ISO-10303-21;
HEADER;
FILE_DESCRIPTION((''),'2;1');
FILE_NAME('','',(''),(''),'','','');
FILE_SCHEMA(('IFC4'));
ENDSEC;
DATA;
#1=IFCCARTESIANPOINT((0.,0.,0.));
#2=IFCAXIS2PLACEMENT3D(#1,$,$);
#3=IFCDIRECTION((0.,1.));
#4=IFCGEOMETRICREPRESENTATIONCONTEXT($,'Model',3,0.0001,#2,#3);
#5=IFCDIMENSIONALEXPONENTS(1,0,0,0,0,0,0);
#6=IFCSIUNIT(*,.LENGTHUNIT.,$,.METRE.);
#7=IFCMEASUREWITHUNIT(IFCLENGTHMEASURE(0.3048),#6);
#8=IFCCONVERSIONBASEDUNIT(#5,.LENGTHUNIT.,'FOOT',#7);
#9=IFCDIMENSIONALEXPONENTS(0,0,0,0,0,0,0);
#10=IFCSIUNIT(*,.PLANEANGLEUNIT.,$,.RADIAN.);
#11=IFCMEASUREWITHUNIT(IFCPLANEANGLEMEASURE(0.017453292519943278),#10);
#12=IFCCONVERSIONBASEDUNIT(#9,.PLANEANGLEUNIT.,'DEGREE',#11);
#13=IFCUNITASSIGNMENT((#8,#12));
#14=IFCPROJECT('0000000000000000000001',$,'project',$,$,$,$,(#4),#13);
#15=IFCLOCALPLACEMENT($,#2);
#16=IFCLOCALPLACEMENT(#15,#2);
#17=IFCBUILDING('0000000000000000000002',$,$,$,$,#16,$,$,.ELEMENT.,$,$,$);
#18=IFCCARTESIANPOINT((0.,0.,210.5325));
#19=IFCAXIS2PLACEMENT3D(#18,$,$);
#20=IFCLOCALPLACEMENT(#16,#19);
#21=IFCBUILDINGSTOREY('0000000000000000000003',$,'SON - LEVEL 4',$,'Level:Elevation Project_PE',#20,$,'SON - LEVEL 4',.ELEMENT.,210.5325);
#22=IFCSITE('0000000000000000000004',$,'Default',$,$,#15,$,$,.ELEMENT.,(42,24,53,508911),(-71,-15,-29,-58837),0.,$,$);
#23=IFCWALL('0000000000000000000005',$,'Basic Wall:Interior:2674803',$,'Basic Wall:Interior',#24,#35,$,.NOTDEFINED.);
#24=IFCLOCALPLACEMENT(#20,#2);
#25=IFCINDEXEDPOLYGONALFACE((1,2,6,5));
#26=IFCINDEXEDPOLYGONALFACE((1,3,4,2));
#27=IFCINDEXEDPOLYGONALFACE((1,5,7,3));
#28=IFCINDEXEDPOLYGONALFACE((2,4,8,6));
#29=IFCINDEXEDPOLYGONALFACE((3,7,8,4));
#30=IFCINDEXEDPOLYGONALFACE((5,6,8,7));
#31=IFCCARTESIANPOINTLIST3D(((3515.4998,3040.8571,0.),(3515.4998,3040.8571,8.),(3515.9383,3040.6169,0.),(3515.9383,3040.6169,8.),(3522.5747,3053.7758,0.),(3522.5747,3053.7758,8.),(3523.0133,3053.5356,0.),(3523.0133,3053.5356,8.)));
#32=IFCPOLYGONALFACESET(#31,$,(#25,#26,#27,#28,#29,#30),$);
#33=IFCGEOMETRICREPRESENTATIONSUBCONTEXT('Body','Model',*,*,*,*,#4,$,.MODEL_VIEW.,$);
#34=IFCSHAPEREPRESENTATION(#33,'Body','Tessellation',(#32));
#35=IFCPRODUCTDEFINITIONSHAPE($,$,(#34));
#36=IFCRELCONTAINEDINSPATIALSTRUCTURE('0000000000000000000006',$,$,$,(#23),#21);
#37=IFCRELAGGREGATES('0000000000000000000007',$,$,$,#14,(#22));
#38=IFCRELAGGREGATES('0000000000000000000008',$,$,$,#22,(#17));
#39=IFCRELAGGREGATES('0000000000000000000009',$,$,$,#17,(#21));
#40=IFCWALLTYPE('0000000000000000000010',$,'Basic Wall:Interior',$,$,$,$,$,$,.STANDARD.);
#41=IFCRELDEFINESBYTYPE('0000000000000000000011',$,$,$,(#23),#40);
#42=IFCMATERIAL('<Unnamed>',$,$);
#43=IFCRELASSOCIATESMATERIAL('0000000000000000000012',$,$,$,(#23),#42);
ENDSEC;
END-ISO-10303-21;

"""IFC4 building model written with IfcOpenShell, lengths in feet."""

from ifc_helpers import new_model, entity, si_unit, converted_unit, direction, frame, origin, place, context, subcontext, project, spatial, indexed_curve, outline, extrude, material, type_object, element, save


model = new_model("IFC4")

# Units and contexts
model_context = context("Model", 3, precision=0.0001, world=origin(), true_north=direction((0.0, 1.0)))
body_context = subcontext(model_context, "Body", "Model", "MODEL_VIEW")
ifc_project = project(units=[converted_unit("LENGTHUNIT", "FOOT", entity("IfcLengthMeasure", 0.3048), si_unit("LENGTHUNIT", "METRE"), dimensions=[1, 0, 0, 0, 0, 0, 0]), converted_unit("PLANEANGLEUNIT", "DEGREE", entity("IfcPlaneAngleMeasure", 0.017453292519943278), si_unit("PLANEANGLEUNIT", "RADIAN"), dimensions=[0, 0, 0, 0, 0, 0, 0])], contexts=[model_context])

# Site, building, storey
site_placement = place(None, origin())
site = spatial("IfcSite", under=ifc_project, at=site_placement, Name="Default", CompositionType="ELEMENT", RefLatitude=(42, 24, 53, 508911), RefLongitude=(-71, -15, -29, -58837), RefElevation=0.0)
building_placement = place(site_placement, origin())
building = spatial("IfcBuilding", under=site, at=building_placement, CompositionType="ELEMENT")
storey_placement = place(building_placement, frame((0.0, 0.0, 210.5325)))
storey = spatial("IfcBuildingStorey", under=building, at=storey_placement, Name="SON - LEVEL 4", ObjectType="Level:Elevation Project_PE", LongName="SON - LEVEL 4", CompositionType="ELEMENT", Elevation=210.5325)

# Wall
ifc_material = material(Name="<Unnamed>")
wall_type = type_object("IfcWallType", Name="Basic Wall:Interior", PredefinedType="STANDARD")
wall_placement = place(storey_placement, frame((3515.719, 3040.737, 0.0), z_axis=(0.0, 0.0, 1.0), x_axis=(0.480336, 0.877084, 0.0)))
element("IfcWall", 1, at=wall_placement, inside=storey, type_object=wall_type, material=ifc_material, Name="Basic Wall:Interior:2674803", ObjectType="Basic Wall:Interior", PredefinedType="NOTDEFINED", context=body_context, shape_type="SweptSolid", body=[
    extrude(outline(indexed_curve([(14.7292, 0.25), (0.0, 0.25), (0.0, -0.25), (14.7292, -0.25), (14.7292, 0.25)], self_intersect=False)), origin(), (0.0, 0.0, 1.0), 8.0),
])

save(model, "model.ifc")
